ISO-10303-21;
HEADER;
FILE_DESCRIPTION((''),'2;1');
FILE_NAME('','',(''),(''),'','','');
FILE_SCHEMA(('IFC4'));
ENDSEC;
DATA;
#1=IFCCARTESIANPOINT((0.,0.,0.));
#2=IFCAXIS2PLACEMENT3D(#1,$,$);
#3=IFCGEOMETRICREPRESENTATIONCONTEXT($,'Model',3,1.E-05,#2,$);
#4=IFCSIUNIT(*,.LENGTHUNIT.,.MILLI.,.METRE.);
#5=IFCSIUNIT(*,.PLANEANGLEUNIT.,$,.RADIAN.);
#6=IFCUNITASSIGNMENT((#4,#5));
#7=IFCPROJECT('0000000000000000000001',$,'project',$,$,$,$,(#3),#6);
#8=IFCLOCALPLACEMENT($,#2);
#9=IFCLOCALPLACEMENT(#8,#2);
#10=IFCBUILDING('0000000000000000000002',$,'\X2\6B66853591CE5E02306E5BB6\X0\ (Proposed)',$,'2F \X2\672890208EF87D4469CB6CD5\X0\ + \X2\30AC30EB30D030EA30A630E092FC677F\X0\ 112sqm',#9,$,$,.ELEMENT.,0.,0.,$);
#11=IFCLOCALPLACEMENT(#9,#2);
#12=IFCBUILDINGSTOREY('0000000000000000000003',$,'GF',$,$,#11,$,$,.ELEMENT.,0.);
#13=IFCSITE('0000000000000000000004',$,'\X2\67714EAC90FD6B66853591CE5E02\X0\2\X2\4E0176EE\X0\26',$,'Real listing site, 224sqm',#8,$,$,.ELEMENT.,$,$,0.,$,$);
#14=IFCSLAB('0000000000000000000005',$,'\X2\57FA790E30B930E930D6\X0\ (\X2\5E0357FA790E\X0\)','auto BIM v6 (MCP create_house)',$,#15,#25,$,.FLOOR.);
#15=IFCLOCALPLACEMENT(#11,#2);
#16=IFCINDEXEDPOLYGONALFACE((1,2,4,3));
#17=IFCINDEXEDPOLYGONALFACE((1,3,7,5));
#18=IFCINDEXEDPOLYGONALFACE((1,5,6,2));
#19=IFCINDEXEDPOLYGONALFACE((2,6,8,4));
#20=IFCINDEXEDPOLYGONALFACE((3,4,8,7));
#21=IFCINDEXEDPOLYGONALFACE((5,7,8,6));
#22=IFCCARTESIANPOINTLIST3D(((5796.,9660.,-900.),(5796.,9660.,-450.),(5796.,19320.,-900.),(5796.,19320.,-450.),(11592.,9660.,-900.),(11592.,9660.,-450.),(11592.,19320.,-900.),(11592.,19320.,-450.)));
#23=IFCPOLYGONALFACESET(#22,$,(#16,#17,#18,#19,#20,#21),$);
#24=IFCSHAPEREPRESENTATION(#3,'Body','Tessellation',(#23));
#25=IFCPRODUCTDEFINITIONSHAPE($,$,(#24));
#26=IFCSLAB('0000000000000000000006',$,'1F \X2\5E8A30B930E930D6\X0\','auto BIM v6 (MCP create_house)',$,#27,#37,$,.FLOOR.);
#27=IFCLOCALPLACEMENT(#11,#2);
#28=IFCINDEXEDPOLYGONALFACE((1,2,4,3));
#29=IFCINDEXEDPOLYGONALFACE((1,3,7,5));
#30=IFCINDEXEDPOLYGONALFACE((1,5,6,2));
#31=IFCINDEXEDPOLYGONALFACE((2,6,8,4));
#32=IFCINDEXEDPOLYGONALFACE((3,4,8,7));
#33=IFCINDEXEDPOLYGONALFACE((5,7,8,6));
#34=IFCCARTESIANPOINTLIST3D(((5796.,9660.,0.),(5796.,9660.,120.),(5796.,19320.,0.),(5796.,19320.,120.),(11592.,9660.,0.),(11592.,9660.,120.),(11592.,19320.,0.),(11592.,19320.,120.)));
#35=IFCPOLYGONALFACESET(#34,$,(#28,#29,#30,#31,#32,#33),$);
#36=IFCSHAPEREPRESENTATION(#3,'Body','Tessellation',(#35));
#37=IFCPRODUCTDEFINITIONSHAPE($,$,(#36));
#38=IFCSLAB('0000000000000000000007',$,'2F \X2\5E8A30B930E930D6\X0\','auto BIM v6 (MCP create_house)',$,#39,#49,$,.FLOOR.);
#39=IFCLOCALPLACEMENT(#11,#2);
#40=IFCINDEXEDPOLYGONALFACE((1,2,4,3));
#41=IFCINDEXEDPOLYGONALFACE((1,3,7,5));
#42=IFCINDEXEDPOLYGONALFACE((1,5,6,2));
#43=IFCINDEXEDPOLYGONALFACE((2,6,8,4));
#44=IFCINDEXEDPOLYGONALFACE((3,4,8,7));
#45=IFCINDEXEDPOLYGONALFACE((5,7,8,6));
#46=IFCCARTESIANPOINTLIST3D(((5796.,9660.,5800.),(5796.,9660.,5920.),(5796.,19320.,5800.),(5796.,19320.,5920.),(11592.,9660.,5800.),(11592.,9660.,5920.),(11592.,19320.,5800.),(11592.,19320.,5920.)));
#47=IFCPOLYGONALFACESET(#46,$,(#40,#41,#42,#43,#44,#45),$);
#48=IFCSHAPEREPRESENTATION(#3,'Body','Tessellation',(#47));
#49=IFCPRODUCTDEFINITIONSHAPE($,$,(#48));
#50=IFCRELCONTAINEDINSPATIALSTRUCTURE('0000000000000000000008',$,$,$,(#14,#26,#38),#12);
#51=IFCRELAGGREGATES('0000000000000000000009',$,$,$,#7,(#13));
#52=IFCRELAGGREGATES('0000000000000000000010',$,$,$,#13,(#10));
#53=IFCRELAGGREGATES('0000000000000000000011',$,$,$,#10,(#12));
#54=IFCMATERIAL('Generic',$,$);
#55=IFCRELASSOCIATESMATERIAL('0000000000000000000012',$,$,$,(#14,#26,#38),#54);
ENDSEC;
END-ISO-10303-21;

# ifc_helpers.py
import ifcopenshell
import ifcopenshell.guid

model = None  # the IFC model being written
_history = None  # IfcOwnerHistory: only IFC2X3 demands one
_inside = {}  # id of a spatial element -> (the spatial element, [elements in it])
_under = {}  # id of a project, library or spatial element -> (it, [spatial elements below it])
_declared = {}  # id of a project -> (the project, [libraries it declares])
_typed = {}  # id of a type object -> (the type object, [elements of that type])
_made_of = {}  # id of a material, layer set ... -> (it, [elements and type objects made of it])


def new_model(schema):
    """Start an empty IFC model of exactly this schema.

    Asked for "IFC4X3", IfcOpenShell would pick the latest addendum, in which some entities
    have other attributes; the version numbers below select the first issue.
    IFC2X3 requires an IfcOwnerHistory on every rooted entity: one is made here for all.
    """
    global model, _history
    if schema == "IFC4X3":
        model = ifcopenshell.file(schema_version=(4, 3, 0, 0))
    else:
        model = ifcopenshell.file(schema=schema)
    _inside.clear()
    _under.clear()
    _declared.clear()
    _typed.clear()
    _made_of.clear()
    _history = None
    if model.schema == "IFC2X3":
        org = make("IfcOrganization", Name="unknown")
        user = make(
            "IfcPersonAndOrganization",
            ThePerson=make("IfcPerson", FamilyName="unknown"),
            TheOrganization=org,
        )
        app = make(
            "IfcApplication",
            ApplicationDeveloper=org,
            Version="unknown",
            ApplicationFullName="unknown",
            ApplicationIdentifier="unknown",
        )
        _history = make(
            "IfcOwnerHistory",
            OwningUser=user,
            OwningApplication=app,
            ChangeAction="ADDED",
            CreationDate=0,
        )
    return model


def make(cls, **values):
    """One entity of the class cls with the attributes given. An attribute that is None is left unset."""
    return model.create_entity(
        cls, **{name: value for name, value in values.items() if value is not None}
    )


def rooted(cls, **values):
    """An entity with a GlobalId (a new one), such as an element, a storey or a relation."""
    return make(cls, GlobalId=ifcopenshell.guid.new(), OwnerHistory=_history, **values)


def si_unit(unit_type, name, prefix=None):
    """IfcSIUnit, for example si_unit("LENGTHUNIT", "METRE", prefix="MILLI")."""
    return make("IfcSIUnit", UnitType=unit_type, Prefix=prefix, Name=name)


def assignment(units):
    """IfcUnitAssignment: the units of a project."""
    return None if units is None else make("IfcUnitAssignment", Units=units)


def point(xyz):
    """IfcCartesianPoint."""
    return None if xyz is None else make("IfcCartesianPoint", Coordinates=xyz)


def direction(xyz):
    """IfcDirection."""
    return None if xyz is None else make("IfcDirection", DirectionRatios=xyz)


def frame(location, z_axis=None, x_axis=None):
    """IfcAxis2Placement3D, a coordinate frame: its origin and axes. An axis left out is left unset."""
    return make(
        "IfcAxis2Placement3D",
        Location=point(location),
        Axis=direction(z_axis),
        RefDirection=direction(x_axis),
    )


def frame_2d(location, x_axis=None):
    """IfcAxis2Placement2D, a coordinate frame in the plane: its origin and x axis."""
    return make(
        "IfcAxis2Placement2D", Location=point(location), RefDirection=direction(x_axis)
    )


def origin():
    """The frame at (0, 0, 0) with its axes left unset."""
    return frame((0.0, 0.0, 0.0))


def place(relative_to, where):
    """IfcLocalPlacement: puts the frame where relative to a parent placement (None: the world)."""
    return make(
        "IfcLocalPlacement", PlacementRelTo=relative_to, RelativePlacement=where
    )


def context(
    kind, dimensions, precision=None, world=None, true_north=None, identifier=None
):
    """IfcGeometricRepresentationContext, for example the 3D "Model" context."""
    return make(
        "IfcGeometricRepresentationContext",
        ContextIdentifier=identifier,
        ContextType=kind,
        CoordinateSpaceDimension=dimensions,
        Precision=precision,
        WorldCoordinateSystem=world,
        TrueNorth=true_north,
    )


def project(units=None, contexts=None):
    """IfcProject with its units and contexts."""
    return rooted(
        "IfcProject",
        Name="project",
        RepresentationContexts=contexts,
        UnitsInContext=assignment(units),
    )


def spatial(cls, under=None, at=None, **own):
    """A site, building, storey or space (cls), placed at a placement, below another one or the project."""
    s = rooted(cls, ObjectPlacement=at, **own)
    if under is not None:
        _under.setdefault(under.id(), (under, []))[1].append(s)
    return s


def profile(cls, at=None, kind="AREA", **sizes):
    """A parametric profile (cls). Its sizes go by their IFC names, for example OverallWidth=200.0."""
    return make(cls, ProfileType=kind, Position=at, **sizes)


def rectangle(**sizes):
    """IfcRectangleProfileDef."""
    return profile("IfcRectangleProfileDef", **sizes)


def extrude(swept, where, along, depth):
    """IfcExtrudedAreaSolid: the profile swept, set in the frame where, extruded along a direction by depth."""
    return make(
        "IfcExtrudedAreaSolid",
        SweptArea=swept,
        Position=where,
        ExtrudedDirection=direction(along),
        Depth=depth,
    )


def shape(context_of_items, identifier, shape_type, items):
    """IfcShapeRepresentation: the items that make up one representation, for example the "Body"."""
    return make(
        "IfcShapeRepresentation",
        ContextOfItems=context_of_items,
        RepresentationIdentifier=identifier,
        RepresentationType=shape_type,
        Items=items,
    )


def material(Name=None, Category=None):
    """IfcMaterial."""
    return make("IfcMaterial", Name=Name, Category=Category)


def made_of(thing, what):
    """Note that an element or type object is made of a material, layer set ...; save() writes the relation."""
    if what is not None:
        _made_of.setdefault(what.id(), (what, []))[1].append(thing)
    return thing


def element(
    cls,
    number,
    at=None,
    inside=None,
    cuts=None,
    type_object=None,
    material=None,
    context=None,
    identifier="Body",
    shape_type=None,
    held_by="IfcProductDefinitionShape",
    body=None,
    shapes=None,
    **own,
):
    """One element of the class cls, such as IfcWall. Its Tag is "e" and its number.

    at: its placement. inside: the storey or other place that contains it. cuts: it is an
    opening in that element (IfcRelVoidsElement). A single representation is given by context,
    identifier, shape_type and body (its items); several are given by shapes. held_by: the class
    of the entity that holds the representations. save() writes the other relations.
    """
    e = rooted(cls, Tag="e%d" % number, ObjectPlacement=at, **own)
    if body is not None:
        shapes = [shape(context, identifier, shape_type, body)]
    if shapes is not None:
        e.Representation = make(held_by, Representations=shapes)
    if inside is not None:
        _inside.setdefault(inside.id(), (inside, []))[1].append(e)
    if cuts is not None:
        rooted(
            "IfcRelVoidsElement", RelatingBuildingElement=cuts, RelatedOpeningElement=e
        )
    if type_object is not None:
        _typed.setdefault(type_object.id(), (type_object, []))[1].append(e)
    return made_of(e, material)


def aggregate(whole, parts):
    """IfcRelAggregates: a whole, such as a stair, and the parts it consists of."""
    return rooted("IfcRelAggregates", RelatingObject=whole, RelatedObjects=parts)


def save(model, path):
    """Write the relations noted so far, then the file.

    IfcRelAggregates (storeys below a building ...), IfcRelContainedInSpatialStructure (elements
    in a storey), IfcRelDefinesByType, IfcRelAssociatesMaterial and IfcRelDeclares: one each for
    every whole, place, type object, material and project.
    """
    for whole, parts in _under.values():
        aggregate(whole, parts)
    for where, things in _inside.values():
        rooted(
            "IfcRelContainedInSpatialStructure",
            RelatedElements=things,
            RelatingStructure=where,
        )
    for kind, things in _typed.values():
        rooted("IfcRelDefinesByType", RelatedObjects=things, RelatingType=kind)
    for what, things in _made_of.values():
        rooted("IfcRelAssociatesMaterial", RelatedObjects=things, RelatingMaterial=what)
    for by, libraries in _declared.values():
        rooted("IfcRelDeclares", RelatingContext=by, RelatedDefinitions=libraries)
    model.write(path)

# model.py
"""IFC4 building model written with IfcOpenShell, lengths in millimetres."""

from ifc_helpers import new_model, si_unit, frame, frame_2d, origin, place, context, project, spatial, rectangle, extrude, material, element, save


model = new_model("IFC4")

# Units and contexts
model_context = context("Model", 3, precision=1e-05, world=origin())
ifc_project = project(units=[si_unit("LENGTHUNIT", "METRE", prefix="MILLI"), si_unit("PLANEANGLEUNIT", "RADIAN")], contexts=[model_context])

# Site, building, storey
site_placement = place(None, origin())
site = spatial("IfcSite", under=ifc_project, at=site_placement, Name="東京都武蔵野市2丁目26", ObjectType="Real listing site, 224sqm", CompositionType="ELEMENT", RefElevation=0.0)
building_placement = place(site_placement, origin())
building = spatial("IfcBuilding", under=site, at=building_placement, Name="武蔵野市の家 (Proposed)", ObjectType="2F 木造軸組構法 + ガルバリウム鋼板 112sqm", CompositionType="ELEMENT", ElevationOfRefHeight=0.0, ElevationOfTerrain=0.0)
storey_placement = place(building_placement, origin())
storey = spatial("IfcBuildingStorey", under=building, at=storey_placement, Name="GF", CompositionType="ELEMENT", Elevation=0.0)

# Slabs
ifc_material = material(Name="Generic")
slab_1_placement = place(storey_placement, frame((2898.0, 4830.0, -450.0)))
element("IfcSlab", 1, at=slab_1_placement, inside=storey, material=ifc_material, Name="基礎スラブ (布基礎)", Description="auto BIM v6 (MCP create_house)", PredefinedType="FLOOR", context=model_context, shape_type="SweptSolid", body=[
    extrude(rectangle(XDim=5796.0, YDim=9660.0, at=frame_2d((2898.0, 4830.0))), frame((2898.0, 4830.0, -450.0)), (0.0, 0.0, 1.0), 450.0),
])
slab_2_placement = place(storey_placement, frame((2898.0, 4830.0, 0.0)))
element("IfcSlab", 2, at=slab_2_placement, inside=storey, material=ifc_material, Name="1F 床スラブ", Description="auto BIM v6 (MCP create_house)", PredefinedType="FLOOR", context=model_context, shape_type="SweptSolid", body=[
    extrude(rectangle(XDim=5796.0, YDim=9660.0, at=frame_2d((2898.0, 4830.0))), frame((2898.0, 4830.0, 0.0)), (0.0, 0.0, 1.0), 120.0),
])
slab_3_placement = place(storey_placement, frame((2898.0, 4830.0, 2900.0)))
element("IfcSlab", 3, at=slab_3_placement, inside=storey, material=ifc_material, Name="2F 床スラブ", Description="auto BIM v6 (MCP create_house)", PredefinedType="FLOOR", context=model_context, shape_type="SweptSolid", body=[
    extrude(rectangle(XDim=5796.0, YDim=9660.0, at=frame_2d((2898.0, 4830.0))), frame((2898.0, 4830.0, 2900.0)), (0.0, 0.0, 1.0), 120.0),
])

save(model, "model.ifc")
